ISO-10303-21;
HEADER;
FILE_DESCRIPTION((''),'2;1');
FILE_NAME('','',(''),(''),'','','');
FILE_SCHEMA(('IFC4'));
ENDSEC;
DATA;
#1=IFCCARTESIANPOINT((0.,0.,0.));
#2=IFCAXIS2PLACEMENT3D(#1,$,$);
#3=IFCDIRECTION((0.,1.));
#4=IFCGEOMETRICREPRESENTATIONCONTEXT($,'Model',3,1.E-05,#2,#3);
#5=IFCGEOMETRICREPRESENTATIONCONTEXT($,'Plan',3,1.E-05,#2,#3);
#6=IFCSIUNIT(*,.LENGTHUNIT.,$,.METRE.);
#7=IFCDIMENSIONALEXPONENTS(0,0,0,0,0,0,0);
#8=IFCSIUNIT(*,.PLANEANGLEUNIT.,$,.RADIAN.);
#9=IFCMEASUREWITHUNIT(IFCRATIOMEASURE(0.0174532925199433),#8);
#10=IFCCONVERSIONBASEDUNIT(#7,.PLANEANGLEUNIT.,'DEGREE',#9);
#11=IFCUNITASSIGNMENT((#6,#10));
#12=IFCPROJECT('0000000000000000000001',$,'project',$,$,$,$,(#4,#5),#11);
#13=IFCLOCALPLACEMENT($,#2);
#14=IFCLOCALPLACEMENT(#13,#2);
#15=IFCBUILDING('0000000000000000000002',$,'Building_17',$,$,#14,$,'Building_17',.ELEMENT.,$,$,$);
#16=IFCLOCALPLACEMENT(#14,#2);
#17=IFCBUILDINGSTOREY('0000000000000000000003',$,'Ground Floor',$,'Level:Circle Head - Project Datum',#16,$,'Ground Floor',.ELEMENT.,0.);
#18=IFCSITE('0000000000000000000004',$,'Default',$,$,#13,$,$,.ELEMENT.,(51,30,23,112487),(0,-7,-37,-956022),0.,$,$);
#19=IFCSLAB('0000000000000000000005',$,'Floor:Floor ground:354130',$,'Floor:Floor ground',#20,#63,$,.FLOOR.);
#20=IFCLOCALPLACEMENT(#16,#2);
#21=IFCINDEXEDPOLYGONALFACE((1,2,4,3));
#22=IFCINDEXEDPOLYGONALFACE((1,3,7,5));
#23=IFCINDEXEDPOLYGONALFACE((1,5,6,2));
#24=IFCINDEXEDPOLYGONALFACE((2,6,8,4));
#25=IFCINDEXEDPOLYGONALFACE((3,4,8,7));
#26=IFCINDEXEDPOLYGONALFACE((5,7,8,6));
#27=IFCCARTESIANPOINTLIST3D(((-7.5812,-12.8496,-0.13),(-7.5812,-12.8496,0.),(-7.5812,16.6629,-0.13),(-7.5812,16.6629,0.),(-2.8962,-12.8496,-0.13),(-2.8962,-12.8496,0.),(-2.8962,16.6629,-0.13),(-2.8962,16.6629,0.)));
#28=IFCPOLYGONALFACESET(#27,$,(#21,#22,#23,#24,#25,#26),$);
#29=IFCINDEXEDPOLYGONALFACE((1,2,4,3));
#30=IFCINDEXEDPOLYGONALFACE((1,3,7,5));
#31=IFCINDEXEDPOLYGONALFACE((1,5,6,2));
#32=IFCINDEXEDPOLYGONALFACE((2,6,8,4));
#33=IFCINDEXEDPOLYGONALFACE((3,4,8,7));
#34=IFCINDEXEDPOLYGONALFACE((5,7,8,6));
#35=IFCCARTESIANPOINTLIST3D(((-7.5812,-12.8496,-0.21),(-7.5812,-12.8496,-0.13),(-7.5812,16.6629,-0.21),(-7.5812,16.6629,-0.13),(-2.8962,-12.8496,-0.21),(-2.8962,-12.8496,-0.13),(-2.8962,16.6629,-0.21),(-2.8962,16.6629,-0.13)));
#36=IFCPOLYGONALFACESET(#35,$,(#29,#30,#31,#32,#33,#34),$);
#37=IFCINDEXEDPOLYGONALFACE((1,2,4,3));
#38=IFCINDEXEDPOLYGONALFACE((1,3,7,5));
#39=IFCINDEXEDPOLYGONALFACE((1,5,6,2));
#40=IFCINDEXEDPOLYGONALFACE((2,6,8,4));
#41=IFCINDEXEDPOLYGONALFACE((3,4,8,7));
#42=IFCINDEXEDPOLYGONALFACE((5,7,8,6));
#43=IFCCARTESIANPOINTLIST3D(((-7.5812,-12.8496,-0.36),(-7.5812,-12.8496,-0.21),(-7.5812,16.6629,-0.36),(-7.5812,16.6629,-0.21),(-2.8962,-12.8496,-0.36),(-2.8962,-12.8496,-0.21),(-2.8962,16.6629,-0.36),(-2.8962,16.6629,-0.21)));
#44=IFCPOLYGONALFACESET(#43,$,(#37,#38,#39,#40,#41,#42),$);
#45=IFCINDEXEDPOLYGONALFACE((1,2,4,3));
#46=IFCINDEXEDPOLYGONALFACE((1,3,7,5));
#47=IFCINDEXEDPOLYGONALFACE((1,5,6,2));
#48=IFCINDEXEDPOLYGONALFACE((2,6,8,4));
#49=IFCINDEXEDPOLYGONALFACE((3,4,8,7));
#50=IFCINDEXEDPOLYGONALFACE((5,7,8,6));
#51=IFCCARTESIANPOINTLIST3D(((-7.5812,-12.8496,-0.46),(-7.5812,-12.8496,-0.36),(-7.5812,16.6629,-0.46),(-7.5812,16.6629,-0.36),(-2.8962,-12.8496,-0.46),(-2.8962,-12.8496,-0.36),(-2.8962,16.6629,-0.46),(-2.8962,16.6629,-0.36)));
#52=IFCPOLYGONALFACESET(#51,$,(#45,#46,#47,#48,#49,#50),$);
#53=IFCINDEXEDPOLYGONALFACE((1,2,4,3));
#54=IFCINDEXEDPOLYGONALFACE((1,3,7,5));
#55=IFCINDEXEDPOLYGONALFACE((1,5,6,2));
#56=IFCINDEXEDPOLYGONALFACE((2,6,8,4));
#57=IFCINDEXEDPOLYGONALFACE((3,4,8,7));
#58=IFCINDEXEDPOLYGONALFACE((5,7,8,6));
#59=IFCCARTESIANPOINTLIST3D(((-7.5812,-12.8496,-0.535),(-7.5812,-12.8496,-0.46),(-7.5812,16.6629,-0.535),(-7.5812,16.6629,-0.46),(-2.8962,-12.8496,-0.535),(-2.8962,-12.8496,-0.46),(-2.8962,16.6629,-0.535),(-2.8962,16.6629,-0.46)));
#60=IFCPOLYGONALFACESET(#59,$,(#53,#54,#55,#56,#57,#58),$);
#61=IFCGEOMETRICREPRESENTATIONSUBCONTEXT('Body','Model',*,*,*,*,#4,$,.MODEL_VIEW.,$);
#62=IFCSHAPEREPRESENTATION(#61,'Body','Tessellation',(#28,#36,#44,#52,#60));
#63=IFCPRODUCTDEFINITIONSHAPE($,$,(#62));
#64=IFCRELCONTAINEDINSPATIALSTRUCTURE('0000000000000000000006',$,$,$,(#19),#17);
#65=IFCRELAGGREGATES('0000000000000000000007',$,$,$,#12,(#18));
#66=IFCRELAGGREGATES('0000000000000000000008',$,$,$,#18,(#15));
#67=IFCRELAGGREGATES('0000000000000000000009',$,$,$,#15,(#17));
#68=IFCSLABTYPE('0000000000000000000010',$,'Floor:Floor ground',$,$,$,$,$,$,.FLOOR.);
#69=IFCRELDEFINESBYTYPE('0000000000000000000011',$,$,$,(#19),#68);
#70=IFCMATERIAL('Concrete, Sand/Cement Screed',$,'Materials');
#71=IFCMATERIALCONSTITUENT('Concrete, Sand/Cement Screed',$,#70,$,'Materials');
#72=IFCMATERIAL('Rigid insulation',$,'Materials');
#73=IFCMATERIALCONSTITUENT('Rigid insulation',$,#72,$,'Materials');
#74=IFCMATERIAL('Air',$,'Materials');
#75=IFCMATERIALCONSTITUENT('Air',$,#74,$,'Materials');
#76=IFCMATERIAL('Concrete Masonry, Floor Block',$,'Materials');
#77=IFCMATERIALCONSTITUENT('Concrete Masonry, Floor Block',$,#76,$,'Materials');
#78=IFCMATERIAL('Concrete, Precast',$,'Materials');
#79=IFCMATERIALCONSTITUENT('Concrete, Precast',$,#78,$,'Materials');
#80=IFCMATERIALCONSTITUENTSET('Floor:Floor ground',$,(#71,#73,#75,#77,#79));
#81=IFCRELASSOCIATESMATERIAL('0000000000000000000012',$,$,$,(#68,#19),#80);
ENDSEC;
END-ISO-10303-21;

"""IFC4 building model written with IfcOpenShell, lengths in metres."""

from ifc_helpers import new_model, entity, si_unit, converted_unit, direction, frame, origin, place, context, subcontext, project, spatial, indexed_curve, outline, extrude, material, constituent, constituent_set, type_object, element, save


model = new_model("IFC4")

# Units and contexts
model_context = context("Model", 3, precision=1e-05, world=origin(), true_north=direction((0.0, 1.0)))
plan_context = context("Plan", 3, precision=1e-05, world=origin(), true_north=direction((0.0, 1.0)))
body_context = subcontext(model_context, "Body", "Model", "MODEL_VIEW")
ifc_project = project(units=[si_unit("LENGTHUNIT", "METRE"), converted_unit("PLANEANGLEUNIT", "DEGREE", entity("IfcRatioMeasure", 0.0174532925199433), si_unit("PLANEANGLEUNIT", "RADIAN"), dimensions=[0, 0, 0, 0, 0, 0, 0])], contexts=[model_context, plan_context])

# Site, building, storey
site_placement = place(None, origin())
site = spatial("IfcSite", under=ifc_project, at=site_placement, Name="Default", CompositionType="ELEMENT", RefLatitude=(51, 30, 23, 112487), RefLongitude=(0, -7, -37, -956022), RefElevation=0.0)
building_placement = place(site_placement, origin())
building = spatial("IfcBuilding", under=site, at=building_placement, Name="Building_17", LongName="Building_17", CompositionType="ELEMENT")
storey_placement = place(building_placement, origin())
storey = spatial("IfcBuildingStorey", under=building, at=storey_placement, Name="Ground Floor", ObjectType="Level:Circle Head - Project Datum", LongName="Ground Floor", CompositionType="ELEMENT", Elevation=0.0)

# Slab
ifc_material_1 = material(Name="Concrete, Sand/Cement Screed", Category="Materials")
ifc_constituent_1 = constituent(ifc_material_1, Name="Concrete, Sand/Cement Screed", Category="Materials")
ifc_material_2 = material(Name="Rigid insulation", Category="Materials")
ifc_constituent_2 = constituent(ifc_material_2, Name="Rigid insulation", Category="Materials")
ifc_material_3 = material(Name="Air", Category="Materials")
ifc_constituent_3 = constituent(ifc_material_3, Name="Air", Category="Materials")
ifc_material_4 = material(Name="Concrete Masonry, Floor Block", Category="Materials")
ifc_constituent_4 = constituent(ifc_material_4, Name="Concrete Masonry, Floor Block", Category="Materials")
ifc_material_5 = material(Name="Concrete, Precast", Category="Materials")
ifc_constituent_5 = constituent(ifc_material_5, Name="Concrete, Precast", Category="Materials")
ifc_constituent_set_1 = constituent_set(constituents=[ifc_constituent_1, ifc_constituent_2, ifc_constituent_3, ifc_constituent_4, ifc_constituent_5], Name="Floor:Floor ground")
slab_type = type_object("IfcSlabType", Name="Floor:Floor ground", PredefinedType="FLOOR", material=ifc_constituent_set_1)
slab_placement = place(storey_placement, origin())
element("IfcSlab", 1, at=slab_placement, inside=storey, type_object=slab_type, material=ifc_constituent_set_1, Name="Floor:Floor ground:354130", ObjectType="Floor:Floor ground", PredefinedType="FLOOR", context=body_context, shape_type="SweptSolid", body=[
    extrude(outline(indexed_curve([(-2.3425, -14.7562), (2.3425, -14.7562), (2.3425, 14.7562), (-2.3425, 14.7562), (-2.3425, -14.7562)], self_intersect=False)), frame((-5.2387, 1.9066, -0.13), z_axis=(0.0, 0.0, 1.0), x_axis=(-1.0, 0.0, 0.0)), (0.0, 0.0, 1.0), 0.13),
    extrude(outline(indexed_curve([(-2.3425, -14.7562), (2.3425, -14.7562), (2.3425, 14.7562), (-2.3425, 14.7562), (-2.3425, -14.7562)], self_intersect=False)), frame((-5.2387, 1.9066, -0.21), z_axis=(0.0, 0.0, 1.0), x_axis=(-1.0, 0.0, 0.0)), (0.0, 0.0, 1.0), 0.08),
    extrude(outline(indexed_curve([(-2.3425, -14.7562), (2.3425, -14.7562), (2.3425, 14.7562), (-2.3425, 14.7562), (-2.3425, -14.7562)], self_intersect=False)), frame((-5.2387, 1.9066, -0.36), z_axis=(0.0, 0.0, 1.0), x_axis=(-1.0, 0.0, 0.0)), (0.0, 0.0, 1.0), 0.15),
    extrude(outline(indexed_curve([(-2.3425, -14.7562), (2.3425, -14.7562), (2.3425, 14.7562), (-2.3425, 14.7562), (-2.3425, -14.7562)], self_intersect=False)), frame((-5.2387, 1.9066, -0.46), z_axis=(0.0, 0.0, 1.0), x_axis=(-1.0, 0.0, 0.0)), (0.0, 0.0, 1.0), 0.1),
    extrude(outline(indexed_curve([(-2.3425, -14.7562), (2.3425, -14.7562), (2.3425, 14.7562), (-2.3425, 14.7562), (-2.3425, -14.7562)], self_intersect=False)), frame((-5.2387, 1.9066, -0.535), z_axis=(0.0, 0.0, 1.0), x_axis=(-1.0, 0.0, 0.0)), (0.0, 0.0, 1.0), 0.075),
])

save(model, "model.ifc")
